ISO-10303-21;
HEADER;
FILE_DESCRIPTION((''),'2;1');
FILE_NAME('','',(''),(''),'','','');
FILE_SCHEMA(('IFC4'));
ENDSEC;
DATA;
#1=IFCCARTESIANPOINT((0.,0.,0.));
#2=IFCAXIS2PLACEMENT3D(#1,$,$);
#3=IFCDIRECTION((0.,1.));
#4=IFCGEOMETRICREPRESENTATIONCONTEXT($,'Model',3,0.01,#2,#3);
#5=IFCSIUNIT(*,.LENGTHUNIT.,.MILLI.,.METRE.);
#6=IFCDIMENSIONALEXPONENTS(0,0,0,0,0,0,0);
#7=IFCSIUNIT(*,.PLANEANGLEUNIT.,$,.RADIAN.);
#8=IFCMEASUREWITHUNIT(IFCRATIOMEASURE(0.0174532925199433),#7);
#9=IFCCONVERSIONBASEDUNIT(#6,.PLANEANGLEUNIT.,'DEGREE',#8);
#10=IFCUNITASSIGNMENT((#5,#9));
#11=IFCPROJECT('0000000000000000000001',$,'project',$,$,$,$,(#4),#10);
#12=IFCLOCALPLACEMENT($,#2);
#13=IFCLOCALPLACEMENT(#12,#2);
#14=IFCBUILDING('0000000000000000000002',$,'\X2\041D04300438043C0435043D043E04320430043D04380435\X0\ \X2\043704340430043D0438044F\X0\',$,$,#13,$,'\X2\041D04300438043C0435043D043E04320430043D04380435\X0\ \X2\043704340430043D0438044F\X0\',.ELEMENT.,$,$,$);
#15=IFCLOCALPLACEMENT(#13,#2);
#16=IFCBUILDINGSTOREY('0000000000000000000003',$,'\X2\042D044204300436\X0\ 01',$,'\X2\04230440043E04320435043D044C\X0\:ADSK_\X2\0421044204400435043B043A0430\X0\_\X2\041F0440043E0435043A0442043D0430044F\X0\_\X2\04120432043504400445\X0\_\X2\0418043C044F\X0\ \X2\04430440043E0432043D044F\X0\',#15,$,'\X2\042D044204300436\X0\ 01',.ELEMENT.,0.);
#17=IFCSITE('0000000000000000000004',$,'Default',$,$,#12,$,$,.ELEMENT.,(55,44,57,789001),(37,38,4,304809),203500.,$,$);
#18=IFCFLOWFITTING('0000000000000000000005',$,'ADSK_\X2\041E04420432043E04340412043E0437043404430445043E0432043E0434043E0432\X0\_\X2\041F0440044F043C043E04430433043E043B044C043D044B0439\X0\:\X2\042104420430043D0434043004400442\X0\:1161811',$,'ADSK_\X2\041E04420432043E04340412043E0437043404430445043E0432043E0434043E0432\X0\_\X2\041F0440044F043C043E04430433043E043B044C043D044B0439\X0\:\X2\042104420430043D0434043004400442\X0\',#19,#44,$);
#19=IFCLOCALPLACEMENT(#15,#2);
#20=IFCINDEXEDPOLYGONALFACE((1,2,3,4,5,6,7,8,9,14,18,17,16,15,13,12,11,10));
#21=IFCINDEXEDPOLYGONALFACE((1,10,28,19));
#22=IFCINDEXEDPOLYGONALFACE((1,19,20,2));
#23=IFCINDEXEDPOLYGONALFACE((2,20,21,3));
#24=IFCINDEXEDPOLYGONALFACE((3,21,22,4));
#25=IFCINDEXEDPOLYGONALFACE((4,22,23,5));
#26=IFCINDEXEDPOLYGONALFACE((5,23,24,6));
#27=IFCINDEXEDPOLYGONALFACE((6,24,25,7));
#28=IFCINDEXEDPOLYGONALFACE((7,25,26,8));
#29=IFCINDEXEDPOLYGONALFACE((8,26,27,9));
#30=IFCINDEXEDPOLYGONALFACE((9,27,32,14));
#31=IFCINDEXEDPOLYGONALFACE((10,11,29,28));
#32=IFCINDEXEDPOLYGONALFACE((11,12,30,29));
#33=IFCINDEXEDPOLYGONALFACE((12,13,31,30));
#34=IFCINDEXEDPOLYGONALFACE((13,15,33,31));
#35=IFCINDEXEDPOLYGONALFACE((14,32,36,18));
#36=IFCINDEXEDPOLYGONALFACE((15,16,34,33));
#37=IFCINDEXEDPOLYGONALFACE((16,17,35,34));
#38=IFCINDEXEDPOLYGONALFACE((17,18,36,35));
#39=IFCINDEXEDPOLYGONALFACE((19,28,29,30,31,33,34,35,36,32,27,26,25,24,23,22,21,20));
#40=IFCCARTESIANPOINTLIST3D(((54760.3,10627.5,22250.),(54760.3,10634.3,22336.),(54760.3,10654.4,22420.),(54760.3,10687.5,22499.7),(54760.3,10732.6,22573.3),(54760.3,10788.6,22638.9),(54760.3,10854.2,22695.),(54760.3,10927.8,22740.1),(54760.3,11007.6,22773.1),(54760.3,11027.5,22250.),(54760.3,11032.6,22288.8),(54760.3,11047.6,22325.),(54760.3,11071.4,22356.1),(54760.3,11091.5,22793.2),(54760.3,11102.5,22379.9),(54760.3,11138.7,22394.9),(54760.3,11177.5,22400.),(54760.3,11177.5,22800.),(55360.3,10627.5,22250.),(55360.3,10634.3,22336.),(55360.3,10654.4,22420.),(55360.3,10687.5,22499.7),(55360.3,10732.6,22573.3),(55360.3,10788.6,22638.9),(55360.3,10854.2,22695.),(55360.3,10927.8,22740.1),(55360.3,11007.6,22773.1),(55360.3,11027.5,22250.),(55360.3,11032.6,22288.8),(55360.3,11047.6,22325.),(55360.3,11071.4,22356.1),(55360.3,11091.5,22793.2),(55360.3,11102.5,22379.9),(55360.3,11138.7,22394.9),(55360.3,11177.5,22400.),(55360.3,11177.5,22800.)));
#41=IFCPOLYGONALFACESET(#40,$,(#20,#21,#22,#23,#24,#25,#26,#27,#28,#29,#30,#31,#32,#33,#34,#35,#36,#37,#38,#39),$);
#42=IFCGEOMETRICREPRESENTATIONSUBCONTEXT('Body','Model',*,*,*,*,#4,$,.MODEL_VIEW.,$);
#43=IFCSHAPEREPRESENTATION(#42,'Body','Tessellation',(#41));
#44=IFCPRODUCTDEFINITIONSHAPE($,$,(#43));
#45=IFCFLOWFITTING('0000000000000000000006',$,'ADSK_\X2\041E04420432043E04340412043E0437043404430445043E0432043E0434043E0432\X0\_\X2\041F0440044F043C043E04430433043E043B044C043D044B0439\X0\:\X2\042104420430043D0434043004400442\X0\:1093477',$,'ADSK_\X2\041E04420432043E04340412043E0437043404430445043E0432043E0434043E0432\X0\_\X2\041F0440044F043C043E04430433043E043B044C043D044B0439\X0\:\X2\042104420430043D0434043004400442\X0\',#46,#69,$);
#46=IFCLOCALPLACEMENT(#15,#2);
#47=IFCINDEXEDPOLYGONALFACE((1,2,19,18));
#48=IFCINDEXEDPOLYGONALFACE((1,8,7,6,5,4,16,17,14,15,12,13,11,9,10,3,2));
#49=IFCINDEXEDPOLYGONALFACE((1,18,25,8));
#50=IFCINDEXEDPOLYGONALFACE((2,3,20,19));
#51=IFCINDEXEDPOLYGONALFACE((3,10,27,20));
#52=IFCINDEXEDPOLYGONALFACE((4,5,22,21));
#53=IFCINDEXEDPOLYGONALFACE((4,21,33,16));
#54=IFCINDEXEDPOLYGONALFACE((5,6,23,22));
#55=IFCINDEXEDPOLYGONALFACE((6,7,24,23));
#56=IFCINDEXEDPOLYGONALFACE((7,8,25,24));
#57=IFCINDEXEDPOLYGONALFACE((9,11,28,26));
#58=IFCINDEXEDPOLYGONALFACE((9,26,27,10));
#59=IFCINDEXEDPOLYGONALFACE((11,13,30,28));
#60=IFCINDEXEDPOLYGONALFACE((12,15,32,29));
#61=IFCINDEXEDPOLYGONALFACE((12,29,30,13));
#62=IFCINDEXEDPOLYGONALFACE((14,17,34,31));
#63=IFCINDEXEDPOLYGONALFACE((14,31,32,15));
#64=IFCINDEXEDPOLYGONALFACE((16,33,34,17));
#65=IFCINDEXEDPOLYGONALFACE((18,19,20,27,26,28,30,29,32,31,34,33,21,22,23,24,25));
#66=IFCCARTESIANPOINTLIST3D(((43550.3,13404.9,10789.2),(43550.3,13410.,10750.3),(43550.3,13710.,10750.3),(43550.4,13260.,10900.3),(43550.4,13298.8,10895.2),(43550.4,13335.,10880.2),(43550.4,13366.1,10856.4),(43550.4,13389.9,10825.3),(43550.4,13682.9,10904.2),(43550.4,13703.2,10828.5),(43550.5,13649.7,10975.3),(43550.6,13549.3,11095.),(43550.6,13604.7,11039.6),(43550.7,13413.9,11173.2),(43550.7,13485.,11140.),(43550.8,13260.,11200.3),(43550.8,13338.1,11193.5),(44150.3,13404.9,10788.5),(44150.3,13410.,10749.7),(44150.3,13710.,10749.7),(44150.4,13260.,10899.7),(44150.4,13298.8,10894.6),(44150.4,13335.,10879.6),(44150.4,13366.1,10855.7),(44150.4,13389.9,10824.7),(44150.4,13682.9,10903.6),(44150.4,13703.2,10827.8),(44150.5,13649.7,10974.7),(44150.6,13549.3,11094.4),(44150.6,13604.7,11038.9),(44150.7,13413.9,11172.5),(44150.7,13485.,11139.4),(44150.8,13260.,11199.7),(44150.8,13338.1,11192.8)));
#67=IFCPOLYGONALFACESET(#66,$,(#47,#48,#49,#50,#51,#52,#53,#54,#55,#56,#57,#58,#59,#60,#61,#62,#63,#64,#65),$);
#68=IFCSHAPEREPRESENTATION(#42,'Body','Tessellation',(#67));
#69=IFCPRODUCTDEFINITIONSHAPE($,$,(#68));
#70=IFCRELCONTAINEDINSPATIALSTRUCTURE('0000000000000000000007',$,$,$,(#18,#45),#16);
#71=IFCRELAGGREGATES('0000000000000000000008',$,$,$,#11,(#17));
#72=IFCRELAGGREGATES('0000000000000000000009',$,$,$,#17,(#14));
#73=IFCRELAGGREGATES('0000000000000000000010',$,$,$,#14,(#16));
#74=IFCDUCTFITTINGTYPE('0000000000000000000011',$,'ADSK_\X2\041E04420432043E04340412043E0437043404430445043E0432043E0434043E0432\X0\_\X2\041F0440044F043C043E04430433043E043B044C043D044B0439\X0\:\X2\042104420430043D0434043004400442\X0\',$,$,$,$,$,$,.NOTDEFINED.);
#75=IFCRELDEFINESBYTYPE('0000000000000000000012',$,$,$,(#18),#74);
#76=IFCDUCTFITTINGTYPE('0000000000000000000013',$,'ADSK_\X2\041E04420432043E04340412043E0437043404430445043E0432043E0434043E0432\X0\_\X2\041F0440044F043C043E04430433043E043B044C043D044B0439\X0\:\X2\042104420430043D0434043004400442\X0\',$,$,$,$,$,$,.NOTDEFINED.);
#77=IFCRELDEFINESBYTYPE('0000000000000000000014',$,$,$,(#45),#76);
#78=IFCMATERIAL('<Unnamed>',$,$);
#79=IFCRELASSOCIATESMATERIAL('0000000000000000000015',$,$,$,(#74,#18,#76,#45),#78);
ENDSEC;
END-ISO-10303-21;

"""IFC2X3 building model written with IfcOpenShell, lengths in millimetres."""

from ifc_helpers import new_model, entity, si_unit, converted_unit, direction, frame, frame_2d, origin, place, context, subcontext, project, spatial, polyline, circle_curve, parameter, trimmed, segment, composite_curve, outline, extrude, source, transform, mapped, material, type_object, type_shapes, element, save


model = new_model("IFC2X3")

# Units and contexts
model_context = context("Model", 3, precision=0.01, world=origin(), true_north=direction((0.0, 1.0)))
body_context = subcontext(model_context, "Body", "Model", "MODEL_VIEW")
ifc_project = project(units=[si_unit("LENGTHUNIT", "METRE", prefix="MILLI"), converted_unit("PLANEANGLEUNIT", "DEGREE", entity("IfcRatioMeasure", 0.0174532925199433), si_unit("PLANEANGLEUNIT", "RADIAN"), dimensions=[0, 0, 0, 0, 0, 0, 0])], contexts=[model_context])

# Site, building, storey
site_placement = place(None, origin())
site = spatial("IfcSite", under=ifc_project, at=site_placement, Name="Default", CompositionType="ELEMENT", RefLatitude=(55, 44, 57, 789001), RefLongitude=(37, 38, 4, 304809), RefElevation=203500.0)
building_placement = place(site_placement, origin())
building = spatial("IfcBuilding", under=site, at=building_placement, Name="Наименование здания", LongName="Наименование здания", CompositionType="ELEMENT")
storey_placement = place(building_placement, origin())
storey = spatial("IfcBuildingStorey", under=building, at=storey_placement, Name="Этаж 01", ObjectType="Уровень:ADSK_Стрелка_Проектная_Вверх_Имя уровня", LongName="Этаж 01", CompositionType="ELEMENT", Elevation=0.0)

# Shared definitions
ifc_material_1 = material(Name="<Unnamed>")

# Flow fittings
duct_fitting_type_1 = type_object("IfcDuctFittingType", Name="ADSK_ОтводВоздуховодов_Прямоугольный:Стандарт", PredefinedType="NOTDEFINED", material=ifc_material_1)
shared_shape_1 = source(origin(), body_context, "Body", "SweptSolid", [
    extrude(outline(composite_curve([segment(polyline([(-375.0, -175.0), (25.0, -175.0)]), True, "CONTINUOUS"), segment(trimmed(circle_curve(frame_2d((175.0, -175.0), x_axis=(0.0, 1.0)), 150.0), [parameter(0.0)], [parameter(90.0)], True, "PARAMETER"), False, "CONTINUOUS"), segment(polyline([(175.0, -25.0), (175.0, 375.0)]), True, "CONTINUOUS"), segment(trimmed(circle_curve(frame_2d((175.0, -175.0), x_axis=(0.0, 1.0)), 550.0), [parameter(0.0)], [parameter(90.0)], True, "PARAMETER"), True, "CONTINUOUS")], self_intersect=False)), frame((-175.0, 175.0, -300.0), z_axis=(0.0, 0.0, 1.0), x_axis=(-1.0, 0.0, 0.0)), (0.0, 0.0, 1.0), 600.0),
])
type_shapes(duct_fitting_type_1, [shared_shape_1])
flow_fitting_1_placement = place(storey_placement, frame((55060.3, 10827.5, 22600.0), z_axis=(1.0, 0.0, 0.0), x_axis=(0.0, -1.0, 0.0)))
element("IfcFlowFitting", 1, at=flow_fitting_1_placement, inside=storey, type_object=duct_fitting_type_1, material=ifc_material_1, Name="ADSK_ОтводВоздуховодов_Прямоугольный:Стандарт:1161811", ObjectType="ADSK_ОтводВоздуховодов_Прямоугольный:Стандарт", context=body_context, shape_type="MappedRepresentation", body=[
    mapped(shared_shape_1, transform((0.0, 0.0, 0.0), scale=1.0)),
])
duct_fitting_type_2 = type_object("IfcDuctFittingType", Name="ADSK_ОтводВоздуховодов_Прямоугольный:Стандарт", PredefinedType="NOTDEFINED", material=ifc_material_1)
shared_shape_2 = source(origin(), body_context, "Body", "SweptSolid", [
    extrude(outline(composite_curve([segment(polyline([(-300.0, -150.0), (0.0, -150.0)]), True, "CONTINUOUS"), segment(trimmed(circle_curve(frame_2d((150.0, -150.0), x_axis=(0.0, 1.0)), 150.0), [parameter(0.0)], [parameter(90.0)], True, "PARAMETER"), False, "CONTINUOUS"), segment(polyline([(150.0, 0.0), (150.0, 300.0)]), True, "CONTINUOUS"), segment(trimmed(circle_curve(frame_2d((150.0, -150.0), x_axis=(0.0, 1.0)), 450.0), [parameter(0.0)], [parameter(90.0)], True, "PARAMETER"), True, "CONTINUOUS")], self_intersect=False)), frame((-150.0, 150.0, -300.0), z_axis=(0.0, 0.0, 1.0), x_axis=(-1.0, 0.0, 0.0)), (0.0, 0.0, 1.0), 600.0),
])
type_shapes(duct_fitting_type_2, [shared_shape_2])
flow_fitting_2_placement = place(storey_placement, frame((43850.6, 13560.0, 11050.0), z_axis=(-0.999999, 0.0, 0.0011), x_axis=(0.0, 1.0, 0.0)))
element("IfcFlowFitting", 2, at=flow_fitting_2_placement, inside=storey, type_object=duct_fitting_type_2, material=ifc_material_1, Name="ADSK_ОтводВоздуховодов_Прямоугольный:Стандарт:1093477", ObjectType="ADSK_ОтводВоздуховодов_Прямоугольный:Стандарт", context=body_context, shape_type="MappedRepresentation", body=[
    mapped(shared_shape_2, transform((0.0, 0.0, 0.0), scale=1.0)),
])

save(model, "model.ifc")
